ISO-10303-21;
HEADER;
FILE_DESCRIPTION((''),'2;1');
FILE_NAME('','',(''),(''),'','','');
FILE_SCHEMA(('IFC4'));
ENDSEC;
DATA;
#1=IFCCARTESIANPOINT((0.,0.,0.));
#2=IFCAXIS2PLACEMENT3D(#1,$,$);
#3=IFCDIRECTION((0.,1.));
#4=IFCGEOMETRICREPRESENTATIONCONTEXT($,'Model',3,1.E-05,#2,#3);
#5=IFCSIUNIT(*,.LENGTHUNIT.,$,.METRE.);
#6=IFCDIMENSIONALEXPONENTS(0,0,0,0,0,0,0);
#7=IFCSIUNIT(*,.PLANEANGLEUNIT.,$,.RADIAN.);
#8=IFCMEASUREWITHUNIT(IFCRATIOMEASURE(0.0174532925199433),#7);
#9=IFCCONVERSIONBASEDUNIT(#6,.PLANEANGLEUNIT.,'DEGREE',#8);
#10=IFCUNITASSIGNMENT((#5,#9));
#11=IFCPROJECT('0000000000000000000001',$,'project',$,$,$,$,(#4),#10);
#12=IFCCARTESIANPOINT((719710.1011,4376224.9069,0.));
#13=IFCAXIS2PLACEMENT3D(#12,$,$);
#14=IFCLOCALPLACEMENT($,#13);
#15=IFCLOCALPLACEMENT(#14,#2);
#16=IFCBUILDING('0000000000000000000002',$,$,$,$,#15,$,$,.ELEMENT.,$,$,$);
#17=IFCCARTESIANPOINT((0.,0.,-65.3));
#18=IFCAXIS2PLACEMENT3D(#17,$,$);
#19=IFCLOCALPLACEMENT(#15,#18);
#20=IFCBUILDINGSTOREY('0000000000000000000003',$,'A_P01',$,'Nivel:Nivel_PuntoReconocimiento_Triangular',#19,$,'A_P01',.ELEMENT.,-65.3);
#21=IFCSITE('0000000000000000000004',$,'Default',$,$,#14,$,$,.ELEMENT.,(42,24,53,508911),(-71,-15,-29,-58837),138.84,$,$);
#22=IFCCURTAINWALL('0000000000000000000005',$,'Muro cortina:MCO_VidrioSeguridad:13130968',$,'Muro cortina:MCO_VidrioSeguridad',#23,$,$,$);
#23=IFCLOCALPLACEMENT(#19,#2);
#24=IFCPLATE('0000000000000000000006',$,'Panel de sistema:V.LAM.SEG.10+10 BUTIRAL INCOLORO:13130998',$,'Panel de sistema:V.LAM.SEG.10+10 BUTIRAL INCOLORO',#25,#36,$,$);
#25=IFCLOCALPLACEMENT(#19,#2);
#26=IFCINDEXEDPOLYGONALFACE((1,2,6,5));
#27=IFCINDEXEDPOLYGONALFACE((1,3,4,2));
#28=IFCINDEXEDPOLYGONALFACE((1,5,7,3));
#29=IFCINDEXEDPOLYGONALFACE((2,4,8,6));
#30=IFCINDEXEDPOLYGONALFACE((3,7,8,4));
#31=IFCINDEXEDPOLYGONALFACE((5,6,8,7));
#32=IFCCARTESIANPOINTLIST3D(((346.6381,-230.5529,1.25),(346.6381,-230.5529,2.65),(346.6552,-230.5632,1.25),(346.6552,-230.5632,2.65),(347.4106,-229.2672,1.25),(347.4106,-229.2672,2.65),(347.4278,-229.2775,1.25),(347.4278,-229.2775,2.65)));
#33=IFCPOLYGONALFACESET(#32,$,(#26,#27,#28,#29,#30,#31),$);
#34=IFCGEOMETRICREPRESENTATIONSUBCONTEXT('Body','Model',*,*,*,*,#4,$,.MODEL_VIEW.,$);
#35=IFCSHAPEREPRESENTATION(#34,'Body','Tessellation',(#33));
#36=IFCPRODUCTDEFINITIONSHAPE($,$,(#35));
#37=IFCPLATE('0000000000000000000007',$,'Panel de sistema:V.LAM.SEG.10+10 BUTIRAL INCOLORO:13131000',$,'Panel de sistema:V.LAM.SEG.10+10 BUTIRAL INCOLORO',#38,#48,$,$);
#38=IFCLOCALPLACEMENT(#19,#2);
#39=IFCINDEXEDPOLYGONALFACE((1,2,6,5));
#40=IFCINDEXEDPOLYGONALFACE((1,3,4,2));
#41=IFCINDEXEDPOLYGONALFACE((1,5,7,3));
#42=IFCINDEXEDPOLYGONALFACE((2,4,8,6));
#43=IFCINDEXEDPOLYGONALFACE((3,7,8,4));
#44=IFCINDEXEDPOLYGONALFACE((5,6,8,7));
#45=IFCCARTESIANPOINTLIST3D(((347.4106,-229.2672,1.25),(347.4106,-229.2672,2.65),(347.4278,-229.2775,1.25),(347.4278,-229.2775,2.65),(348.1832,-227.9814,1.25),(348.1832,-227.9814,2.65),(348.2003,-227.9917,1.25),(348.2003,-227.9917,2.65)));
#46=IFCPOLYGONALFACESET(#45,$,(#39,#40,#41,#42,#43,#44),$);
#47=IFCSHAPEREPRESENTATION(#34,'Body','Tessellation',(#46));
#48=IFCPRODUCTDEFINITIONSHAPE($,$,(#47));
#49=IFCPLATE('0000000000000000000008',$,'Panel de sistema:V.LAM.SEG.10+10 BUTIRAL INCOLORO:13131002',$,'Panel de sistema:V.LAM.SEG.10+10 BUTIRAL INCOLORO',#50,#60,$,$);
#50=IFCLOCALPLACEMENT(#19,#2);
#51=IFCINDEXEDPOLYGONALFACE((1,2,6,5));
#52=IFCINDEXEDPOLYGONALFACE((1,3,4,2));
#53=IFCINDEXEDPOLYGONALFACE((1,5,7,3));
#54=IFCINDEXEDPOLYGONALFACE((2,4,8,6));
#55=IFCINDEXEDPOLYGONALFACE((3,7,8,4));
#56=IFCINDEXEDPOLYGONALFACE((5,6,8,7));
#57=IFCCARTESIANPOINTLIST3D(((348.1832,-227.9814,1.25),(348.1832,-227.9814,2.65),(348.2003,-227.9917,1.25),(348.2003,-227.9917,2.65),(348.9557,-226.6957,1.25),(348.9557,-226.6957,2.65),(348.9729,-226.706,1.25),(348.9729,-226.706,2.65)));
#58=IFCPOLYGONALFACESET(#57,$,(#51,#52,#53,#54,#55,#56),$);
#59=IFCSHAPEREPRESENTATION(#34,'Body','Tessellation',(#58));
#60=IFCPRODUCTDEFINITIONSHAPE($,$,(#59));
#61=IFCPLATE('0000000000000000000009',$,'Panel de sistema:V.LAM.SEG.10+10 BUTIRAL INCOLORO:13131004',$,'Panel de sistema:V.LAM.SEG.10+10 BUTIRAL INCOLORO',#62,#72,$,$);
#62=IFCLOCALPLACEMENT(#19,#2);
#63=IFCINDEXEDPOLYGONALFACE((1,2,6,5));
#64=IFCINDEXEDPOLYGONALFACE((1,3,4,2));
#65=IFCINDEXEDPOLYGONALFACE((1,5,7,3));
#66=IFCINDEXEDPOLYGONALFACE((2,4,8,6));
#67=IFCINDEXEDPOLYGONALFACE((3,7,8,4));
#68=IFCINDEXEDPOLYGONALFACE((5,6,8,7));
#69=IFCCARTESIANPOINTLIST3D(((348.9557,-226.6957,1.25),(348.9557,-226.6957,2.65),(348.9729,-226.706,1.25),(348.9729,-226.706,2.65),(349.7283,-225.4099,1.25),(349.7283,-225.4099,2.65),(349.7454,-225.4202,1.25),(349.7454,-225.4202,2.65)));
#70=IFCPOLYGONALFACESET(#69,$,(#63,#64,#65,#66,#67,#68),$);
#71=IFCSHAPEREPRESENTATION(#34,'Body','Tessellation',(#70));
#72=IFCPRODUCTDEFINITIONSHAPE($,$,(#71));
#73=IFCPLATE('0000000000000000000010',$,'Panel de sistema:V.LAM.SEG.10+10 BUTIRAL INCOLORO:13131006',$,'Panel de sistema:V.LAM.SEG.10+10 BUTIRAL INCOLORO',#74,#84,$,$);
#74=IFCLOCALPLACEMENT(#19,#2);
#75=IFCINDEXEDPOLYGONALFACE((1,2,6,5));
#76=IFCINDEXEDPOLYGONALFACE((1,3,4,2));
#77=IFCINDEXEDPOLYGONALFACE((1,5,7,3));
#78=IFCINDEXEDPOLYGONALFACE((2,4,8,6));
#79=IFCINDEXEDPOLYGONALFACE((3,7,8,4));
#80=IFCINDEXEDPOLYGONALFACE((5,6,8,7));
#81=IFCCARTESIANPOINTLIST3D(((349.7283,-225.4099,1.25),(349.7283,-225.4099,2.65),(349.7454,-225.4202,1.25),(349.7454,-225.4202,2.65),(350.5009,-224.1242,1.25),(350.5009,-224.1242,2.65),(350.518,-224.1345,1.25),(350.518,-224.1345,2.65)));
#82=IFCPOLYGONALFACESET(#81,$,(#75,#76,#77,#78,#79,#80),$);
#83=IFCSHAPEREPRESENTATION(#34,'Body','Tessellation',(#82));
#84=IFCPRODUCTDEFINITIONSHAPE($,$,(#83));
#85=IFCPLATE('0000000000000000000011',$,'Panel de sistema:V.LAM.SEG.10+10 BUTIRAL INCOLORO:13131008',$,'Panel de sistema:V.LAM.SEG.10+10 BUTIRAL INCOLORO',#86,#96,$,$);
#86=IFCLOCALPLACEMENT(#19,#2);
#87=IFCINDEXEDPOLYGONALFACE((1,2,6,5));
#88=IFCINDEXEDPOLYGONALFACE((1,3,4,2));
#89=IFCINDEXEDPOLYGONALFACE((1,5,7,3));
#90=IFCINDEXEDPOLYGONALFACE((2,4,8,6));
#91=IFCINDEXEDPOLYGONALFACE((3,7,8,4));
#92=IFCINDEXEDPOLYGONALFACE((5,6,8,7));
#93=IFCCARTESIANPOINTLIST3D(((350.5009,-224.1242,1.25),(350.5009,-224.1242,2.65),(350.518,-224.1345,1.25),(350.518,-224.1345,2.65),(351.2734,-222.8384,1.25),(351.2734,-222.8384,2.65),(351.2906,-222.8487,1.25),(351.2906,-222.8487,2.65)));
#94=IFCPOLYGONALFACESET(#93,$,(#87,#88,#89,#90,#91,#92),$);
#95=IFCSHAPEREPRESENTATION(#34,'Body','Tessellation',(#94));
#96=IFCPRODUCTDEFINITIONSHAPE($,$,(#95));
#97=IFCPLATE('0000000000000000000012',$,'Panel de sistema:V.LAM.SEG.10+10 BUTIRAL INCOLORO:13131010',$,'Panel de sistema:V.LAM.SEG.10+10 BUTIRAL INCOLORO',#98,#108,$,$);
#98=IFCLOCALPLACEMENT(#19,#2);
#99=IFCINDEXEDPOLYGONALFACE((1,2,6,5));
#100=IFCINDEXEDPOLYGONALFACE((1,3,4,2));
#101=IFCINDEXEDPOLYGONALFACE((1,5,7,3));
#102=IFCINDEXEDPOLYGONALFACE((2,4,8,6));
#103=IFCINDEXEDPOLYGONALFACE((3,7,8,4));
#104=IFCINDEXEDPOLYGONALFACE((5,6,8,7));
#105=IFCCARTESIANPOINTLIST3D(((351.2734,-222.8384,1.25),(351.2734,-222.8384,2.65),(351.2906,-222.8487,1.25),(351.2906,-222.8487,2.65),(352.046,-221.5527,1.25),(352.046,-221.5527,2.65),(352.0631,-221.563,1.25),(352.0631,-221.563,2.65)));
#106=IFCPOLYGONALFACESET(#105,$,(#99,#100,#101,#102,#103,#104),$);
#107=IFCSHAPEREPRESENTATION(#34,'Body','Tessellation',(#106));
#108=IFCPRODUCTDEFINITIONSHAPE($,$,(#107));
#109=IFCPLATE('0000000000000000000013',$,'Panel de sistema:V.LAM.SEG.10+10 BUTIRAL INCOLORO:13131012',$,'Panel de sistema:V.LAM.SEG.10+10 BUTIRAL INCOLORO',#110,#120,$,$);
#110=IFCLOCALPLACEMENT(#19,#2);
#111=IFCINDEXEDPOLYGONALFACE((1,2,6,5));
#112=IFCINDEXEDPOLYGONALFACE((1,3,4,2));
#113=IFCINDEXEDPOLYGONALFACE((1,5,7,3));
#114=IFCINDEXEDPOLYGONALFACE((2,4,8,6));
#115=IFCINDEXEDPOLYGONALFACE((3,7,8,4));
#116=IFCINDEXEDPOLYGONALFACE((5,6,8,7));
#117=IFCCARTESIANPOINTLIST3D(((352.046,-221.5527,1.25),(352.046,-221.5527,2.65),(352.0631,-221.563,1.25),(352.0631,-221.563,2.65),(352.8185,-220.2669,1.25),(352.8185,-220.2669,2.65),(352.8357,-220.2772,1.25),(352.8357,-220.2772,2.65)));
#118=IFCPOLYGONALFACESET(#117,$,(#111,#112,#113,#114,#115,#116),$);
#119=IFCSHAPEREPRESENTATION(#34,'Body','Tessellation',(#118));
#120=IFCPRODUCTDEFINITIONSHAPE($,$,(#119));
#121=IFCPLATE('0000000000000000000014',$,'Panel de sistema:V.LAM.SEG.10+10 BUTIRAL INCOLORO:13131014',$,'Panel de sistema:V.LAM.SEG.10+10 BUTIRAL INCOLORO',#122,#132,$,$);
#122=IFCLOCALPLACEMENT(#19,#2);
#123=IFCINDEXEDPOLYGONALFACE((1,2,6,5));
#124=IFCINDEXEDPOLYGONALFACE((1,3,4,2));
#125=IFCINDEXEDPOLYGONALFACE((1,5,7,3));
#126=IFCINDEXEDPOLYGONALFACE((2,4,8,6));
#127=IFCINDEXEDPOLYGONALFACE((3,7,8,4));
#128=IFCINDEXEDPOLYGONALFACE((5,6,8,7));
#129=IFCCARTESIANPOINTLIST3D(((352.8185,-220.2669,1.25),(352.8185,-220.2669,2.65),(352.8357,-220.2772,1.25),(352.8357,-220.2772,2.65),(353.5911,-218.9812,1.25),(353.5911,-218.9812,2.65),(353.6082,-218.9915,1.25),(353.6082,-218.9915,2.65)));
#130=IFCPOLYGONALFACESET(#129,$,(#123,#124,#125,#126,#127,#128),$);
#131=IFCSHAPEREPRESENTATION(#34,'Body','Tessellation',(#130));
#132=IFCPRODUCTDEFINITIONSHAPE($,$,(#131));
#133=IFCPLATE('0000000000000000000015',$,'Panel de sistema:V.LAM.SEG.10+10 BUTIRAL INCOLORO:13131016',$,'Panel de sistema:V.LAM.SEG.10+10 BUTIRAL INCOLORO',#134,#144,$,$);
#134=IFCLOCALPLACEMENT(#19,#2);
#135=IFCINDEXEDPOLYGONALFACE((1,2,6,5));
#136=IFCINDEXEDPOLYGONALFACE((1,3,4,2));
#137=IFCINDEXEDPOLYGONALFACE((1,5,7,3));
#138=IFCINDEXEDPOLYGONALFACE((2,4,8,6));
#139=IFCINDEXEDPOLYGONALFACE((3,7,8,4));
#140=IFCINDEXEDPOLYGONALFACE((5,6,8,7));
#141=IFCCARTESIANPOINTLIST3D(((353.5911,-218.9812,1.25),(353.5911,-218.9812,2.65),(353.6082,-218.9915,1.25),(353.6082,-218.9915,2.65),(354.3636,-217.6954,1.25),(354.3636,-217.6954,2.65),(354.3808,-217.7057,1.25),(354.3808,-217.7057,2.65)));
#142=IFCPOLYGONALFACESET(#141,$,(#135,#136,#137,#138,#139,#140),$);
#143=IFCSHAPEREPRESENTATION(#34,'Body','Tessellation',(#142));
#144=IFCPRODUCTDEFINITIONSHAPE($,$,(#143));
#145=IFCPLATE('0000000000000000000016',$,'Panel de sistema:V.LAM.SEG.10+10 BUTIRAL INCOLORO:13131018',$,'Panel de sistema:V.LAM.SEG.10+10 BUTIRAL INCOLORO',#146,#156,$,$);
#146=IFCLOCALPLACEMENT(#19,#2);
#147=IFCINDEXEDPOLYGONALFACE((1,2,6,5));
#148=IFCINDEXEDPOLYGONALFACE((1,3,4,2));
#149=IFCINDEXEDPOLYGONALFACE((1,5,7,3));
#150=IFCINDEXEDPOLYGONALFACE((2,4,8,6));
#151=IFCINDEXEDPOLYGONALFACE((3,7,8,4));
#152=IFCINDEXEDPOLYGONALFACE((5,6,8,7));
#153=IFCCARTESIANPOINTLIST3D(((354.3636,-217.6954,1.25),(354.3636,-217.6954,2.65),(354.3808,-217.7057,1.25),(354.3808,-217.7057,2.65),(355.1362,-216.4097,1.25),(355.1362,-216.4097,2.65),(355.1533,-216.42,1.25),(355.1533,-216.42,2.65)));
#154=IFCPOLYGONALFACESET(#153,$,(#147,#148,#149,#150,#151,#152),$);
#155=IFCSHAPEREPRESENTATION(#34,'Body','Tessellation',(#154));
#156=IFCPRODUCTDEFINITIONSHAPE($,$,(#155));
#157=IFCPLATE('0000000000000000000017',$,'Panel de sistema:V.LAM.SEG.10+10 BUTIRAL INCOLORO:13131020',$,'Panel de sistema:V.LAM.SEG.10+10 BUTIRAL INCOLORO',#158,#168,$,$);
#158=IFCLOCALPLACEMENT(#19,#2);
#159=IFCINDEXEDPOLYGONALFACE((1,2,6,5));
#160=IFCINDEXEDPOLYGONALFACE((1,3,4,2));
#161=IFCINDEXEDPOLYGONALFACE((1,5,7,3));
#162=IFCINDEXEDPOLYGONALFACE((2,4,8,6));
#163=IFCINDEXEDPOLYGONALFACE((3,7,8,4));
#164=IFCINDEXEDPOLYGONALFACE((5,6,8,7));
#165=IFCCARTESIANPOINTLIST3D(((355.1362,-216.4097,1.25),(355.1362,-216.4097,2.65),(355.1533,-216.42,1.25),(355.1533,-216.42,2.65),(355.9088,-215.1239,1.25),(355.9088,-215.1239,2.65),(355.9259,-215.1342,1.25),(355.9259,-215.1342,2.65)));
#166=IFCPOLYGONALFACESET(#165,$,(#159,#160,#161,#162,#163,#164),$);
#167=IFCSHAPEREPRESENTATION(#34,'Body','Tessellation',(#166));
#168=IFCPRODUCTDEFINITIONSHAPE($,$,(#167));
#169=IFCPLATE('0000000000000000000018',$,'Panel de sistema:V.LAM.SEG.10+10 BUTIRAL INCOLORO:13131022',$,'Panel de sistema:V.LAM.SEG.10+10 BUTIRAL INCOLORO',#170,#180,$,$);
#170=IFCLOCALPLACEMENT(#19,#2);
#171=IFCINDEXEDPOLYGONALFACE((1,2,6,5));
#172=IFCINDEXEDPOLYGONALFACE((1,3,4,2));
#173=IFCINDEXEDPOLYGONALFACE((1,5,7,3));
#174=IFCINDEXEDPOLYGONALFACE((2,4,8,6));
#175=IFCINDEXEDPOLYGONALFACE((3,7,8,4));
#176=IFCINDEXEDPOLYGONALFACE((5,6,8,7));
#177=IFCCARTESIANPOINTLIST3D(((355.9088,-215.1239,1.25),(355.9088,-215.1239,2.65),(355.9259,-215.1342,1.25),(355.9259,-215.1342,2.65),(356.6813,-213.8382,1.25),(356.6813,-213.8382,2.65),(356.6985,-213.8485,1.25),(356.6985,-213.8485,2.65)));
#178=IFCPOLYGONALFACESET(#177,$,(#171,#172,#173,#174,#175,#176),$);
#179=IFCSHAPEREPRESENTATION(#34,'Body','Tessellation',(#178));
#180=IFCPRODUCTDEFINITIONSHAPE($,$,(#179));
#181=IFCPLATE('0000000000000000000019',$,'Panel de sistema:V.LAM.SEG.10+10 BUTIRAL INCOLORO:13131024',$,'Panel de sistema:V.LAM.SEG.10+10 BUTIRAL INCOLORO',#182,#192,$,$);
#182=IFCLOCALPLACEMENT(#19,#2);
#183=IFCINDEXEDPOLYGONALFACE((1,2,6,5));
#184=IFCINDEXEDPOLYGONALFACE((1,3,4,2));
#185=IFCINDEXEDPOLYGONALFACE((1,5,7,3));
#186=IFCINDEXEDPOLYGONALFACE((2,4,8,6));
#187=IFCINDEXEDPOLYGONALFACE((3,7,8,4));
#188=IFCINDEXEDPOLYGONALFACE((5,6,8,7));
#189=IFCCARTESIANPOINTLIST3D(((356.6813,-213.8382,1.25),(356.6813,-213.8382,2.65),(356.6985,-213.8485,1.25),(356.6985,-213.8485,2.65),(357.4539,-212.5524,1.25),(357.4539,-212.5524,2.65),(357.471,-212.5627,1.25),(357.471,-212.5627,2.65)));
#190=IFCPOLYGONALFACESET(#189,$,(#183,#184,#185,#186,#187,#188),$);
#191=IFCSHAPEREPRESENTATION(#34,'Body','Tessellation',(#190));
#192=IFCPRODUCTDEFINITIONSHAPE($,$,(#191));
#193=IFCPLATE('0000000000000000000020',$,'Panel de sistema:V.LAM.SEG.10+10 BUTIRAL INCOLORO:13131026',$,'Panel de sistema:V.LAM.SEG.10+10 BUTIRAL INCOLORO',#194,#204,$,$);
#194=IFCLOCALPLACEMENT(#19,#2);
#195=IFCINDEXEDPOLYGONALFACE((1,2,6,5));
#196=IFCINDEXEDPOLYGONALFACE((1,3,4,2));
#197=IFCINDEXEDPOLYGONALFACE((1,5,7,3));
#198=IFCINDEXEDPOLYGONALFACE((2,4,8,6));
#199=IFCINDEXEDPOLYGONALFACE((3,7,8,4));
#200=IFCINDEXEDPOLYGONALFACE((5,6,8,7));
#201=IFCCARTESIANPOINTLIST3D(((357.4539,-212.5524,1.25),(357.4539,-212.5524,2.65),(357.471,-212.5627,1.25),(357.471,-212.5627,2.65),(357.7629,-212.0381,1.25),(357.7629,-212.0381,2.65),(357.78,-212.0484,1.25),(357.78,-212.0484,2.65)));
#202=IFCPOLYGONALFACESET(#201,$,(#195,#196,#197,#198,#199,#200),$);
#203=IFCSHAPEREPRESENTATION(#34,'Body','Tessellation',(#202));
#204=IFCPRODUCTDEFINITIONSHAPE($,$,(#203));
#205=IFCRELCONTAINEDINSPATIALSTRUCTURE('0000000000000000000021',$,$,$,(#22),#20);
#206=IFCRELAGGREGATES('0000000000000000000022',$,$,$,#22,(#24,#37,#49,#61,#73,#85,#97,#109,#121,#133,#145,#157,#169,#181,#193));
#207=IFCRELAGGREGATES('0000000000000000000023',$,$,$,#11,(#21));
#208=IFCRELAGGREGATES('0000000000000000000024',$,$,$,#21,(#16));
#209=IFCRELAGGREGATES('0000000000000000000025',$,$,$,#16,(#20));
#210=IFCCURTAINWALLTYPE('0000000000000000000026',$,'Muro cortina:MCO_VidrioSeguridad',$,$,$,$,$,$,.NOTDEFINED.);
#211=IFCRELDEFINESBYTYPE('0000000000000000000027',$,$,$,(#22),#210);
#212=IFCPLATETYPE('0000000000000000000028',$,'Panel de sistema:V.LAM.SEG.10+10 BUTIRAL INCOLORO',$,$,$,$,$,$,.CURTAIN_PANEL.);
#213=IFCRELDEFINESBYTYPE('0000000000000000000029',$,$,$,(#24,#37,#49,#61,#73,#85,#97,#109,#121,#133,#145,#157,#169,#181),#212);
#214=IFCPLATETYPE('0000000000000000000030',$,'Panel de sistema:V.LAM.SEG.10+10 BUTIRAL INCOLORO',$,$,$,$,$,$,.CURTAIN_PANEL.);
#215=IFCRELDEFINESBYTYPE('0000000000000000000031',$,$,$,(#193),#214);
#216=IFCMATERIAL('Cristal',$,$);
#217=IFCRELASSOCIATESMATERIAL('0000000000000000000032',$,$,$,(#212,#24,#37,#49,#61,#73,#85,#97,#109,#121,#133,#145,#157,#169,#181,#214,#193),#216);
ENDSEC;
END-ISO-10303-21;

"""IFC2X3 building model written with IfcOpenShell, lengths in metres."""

from ifc_helpers import new_model, entity, si_unit, converted_unit, direction, frame, origin, origin_2d_with_axis, place, context, subcontext, project, spatial, rectangle, extrude, source, transform, mapped, material, type_object, type_shapes, element, aggregate, save


model = new_model("IFC2X3")

# Units and contexts
model_context = context("Model", 3, precision=1e-05, world=origin(), true_north=direction((0.0, 1.0)))
body_context = subcontext(model_context, "Body", "Model", "MODEL_VIEW")
ifc_project = project(units=[si_unit("LENGTHUNIT", "METRE"), converted_unit("PLANEANGLEUNIT", "DEGREE", entity("IfcRatioMeasure", 0.0174532925199433), si_unit("PLANEANGLEUNIT", "RADIAN"), dimensions=[0, 0, 0, 0, 0, 0, 0])], contexts=[model_context])

# Site, building, storey
site_placement = place(None, frame((719710.1011, 4376224.9069, 0.0)))
site = spatial("IfcSite", under=ifc_project, at=site_placement, Name="Default", CompositionType="ELEMENT", RefLatitude=(42, 24, 53, 508911), RefLongitude=(-71, -15, -29, -58837), RefElevation=138.84)
building_placement = place(site_placement, origin())
building = spatial("IfcBuilding", under=site, at=building_placement, CompositionType="ELEMENT")
storey_placement = place(building_placement, frame((0.0, 0.0, -65.3)))
storey = spatial("IfcBuildingStorey", under=building, at=storey_placement, Name="A_P01", ObjectType="Nivel:Nivel_PuntoReconocimiento_Triangular", LongName="A_P01", CompositionType="ELEMENT", Elevation=-65.3)

# Curtain wall, plates
curtain_wall_type = type_object("IfcCurtainWallType", Name="Muro cortina:MCO_VidrioSeguridad", PredefinedType="NOTDEFINED")
curtain_wall_placement = place(storey_placement, frame((0.0, 0.0, 65.3)))
curtain_wall = element("IfcCurtainWall", 1, at=curtain_wall_placement, inside=storey, type_object=curtain_wall_type, Name="Muro cortina:MCO_VidrioSeguridad:13130968", ObjectType="Muro cortina:MCO_VidrioSeguridad")
ifc_material_1 = material(Name="Cristal")
plate_type_1 = type_object("IfcPlateType", Name="Panel de sistema:V.LAM.SEG.10+10 BUTIRAL INCOLORO", PredefinedType="CURTAIN_PANEL", material=ifc_material_1)
shared_shape_1 = source(origin(), body_context, "Body", "SweptSolid", [
    extrude(rectangle(XDim=0.02, YDim=1.5, at=origin_2d_with_axis()), frame((0.0, 0.0, 0.0), z_axis=(0.0, 0.0, 1.0), x_axis=(0.0, 1.0, 0.0)), (0.0, 0.0, 1.0), 1.4),
])
type_shapes(plate_type_1, [shared_shape_1])
plate_1_placement = place(curtain_wall_placement, frame((347.0329, -229.9152, -64.05), z_axis=(0.0, 0.0, 1.0), x_axis=(0.515038, 0.857167, 0.0)))
plate_1 = element("IfcPlate", 2, at=plate_1_placement, type_object=plate_type_1, material=ifc_material_1, Name="Panel de sistema:V.LAM.SEG.10+10 BUTIRAL INCOLORO:13130998", ObjectType="Panel de sistema:V.LAM.SEG.10+10 BUTIRAL INCOLORO", context=body_context, shape_type="MappedRepresentation", body=[
    mapped(shared_shape_1, transform((0.0, 0.0, 0.0), scale=1.0)),
])
plate_2_placement = place(curtain_wall_placement, frame((347.8055, -228.6294, -64.05), z_axis=(0.0, 0.0, 1.0), x_axis=(0.515038, 0.857167, 0.0)))
plate_2 = element("IfcPlate", 3, at=plate_2_placement, type_object=plate_type_1, material=ifc_material_1, Name="Panel de sistema:V.LAM.SEG.10+10 BUTIRAL INCOLORO:13131000", ObjectType="Panel de sistema:V.LAM.SEG.10+10 BUTIRAL INCOLORO", context=body_context, shape_type="MappedRepresentation", body=[
    mapped(shared_shape_1, transform((0.0, 0.0, 0.0), scale=1.0)),
])
plate_3_placement = place(curtain_wall_placement, frame((348.578, -227.3437, -64.05), z_axis=(0.0, 0.0, 1.0), x_axis=(0.515038, 0.857167, 0.0)))
plate_3 = element("IfcPlate", 4, at=plate_3_placement, type_object=plate_type_1, material=ifc_material_1, Name="Panel de sistema:V.LAM.SEG.10+10 BUTIRAL INCOLORO:13131002", ObjectType="Panel de sistema:V.LAM.SEG.10+10 BUTIRAL INCOLORO", context=body_context, shape_type="MappedRepresentation", body=[
    mapped(shared_shape_1, transform((0.0, 0.0, 0.0), scale=1.0)),
])
plate_4_placement = place(curtain_wall_placement, frame((349.3506, -226.0579, -64.05), z_axis=(0.0, 0.0, 1.0), x_axis=(0.515038, 0.857167, 0.0)))
plate_4 = element("IfcPlate", 5, at=plate_4_placement, type_object=plate_type_1, material=ifc_material_1, Name="Panel de sistema:V.LAM.SEG.10+10 BUTIRAL INCOLORO:13131004", ObjectType="Panel de sistema:V.LAM.SEG.10+10 BUTIRAL INCOLORO", context=body_context, shape_type="MappedRepresentation", body=[
    mapped(shared_shape_1, transform((0.0, 0.0, 0.0), scale=1.0)),
])
plate_5_placement = place(curtain_wall_placement, frame((350.1232, -224.7722, -64.05), z_axis=(0.0, 0.0, 1.0), x_axis=(0.515038, 0.857167, 0.0)))
plate_5 = element("IfcPlate", 6, at=plate_5_placement, type_object=plate_type_1, material=ifc_material_1, Name="Panel de sistema:V.LAM.SEG.10+10 BUTIRAL INCOLORO:13131006", ObjectType="Panel de sistema:V.LAM.SEG.10+10 BUTIRAL INCOLORO", context=body_context, shape_type="MappedRepresentation", body=[
    mapped(shared_shape_1, transform((0.0, 0.0, 0.0), scale=1.0)),
])
plate_6_placement = place(curtain_wall_placement, frame((350.8957, -223.4864, -64.05), z_axis=(0.0, 0.0, 1.0), x_axis=(0.515038, 0.857167, 0.0)))
plate_6 = element("IfcPlate", 7, at=plate_6_placement, type_object=plate_type_1, material=ifc_material_1, Name="Panel de sistema:V.LAM.SEG.10+10 BUTIRAL INCOLORO:13131008", ObjectType="Panel de sistema:V.LAM.SEG.10+10 BUTIRAL INCOLORO", context=body_context, shape_type="MappedRepresentation", body=[
    mapped(shared_shape_1, transform((0.0, 0.0, 0.0), scale=1.0)),
])
plate_7_placement = place(curtain_wall_placement, frame((351.6683, -222.2007, -64.05), z_axis=(0.0, 0.0, 1.0), x_axis=(0.515038, 0.857167, 0.0)))
plate_7 = element("IfcPlate", 8, at=plate_7_placement, type_object=plate_type_1, material=ifc_material_1, Name="Panel de sistema:V.LAM.SEG.10+10 BUTIRAL INCOLORO:13131010", ObjectType="Panel de sistema:V.LAM.SEG.10+10 BUTIRAL INCOLORO", context=body_context, shape_type="MappedRepresentation", body=[
    mapped(shared_shape_1, transform((0.0, 0.0, 0.0), scale=1.0)),
])
plate_8_placement = place(curtain_wall_placement, frame((352.4408, -220.9149, -64.05), z_axis=(0.0, 0.0, 1.0), x_axis=(0.515038, 0.857167, 0.0)))
plate_8 = element("IfcPlate", 9, at=plate_8_placement, type_object=plate_type_1, material=ifc_material_1, Name="Panel de sistema:V.LAM.SEG.10+10 BUTIRAL INCOLORO:13131012", ObjectType="Panel de sistema:V.LAM.SEG.10+10 BUTIRAL INCOLORO", context=body_context, shape_type="MappedRepresentation", body=[
    mapped(shared_shape_1, transform((0.0, 0.0, 0.0), scale=1.0)),
])
plate_9_placement = place(curtain_wall_placement, frame((353.2134, -219.6292, -64.05), z_axis=(0.0, 0.0, 1.0), x_axis=(0.515038, 0.857167, 0.0)))
plate_9 = element("IfcPlate", 10, at=plate_9_placement, type_object=plate_type_1, material=ifc_material_1, Name="Panel de sistema:V.LAM.SEG.10+10 BUTIRAL INCOLORO:13131014", ObjectType="Panel de sistema:V.LAM.SEG.10+10 BUTIRAL INCOLORO", context=body_context, shape_type="MappedRepresentation", body=[
    mapped(shared_shape_1, transform((0.0, 0.0, 0.0), scale=1.0)),
])
plate_10_placement = place(curtain_wall_placement, frame((353.9859, -218.3434, -64.05), z_axis=(0.0, 0.0, 1.0), x_axis=(0.515038, 0.857167, 0.0)))
plate_10 = element("IfcPlate", 11, at=plate_10_placement, type_object=plate_type_1, material=ifc_material_1, Name="Panel de sistema:V.LAM.SEG.10+10 BUTIRAL INCOLORO:13131016", ObjectType="Panel de sistema:V.LAM.SEG.10+10 BUTIRAL INCOLORO", context=body_context, shape_type="MappedRepresentation", body=[
    mapped(shared_shape_1, transform((0.0, 0.0, 0.0), scale=1.0)),
])
plate_11_placement = place(curtain_wall_placement, frame((354.7585, -217.0577, -64.05), z_axis=(0.0, 0.0, 1.0), x_axis=(0.515038, 0.857167, 0.0)))
plate_11 = element("IfcPlate", 12, at=plate_11_placement, type_object=plate_type_1, material=ifc_material_1, Name="Panel de sistema:V.LAM.SEG.10+10 BUTIRAL INCOLORO:13131018", ObjectType="Panel de sistema:V.LAM.SEG.10+10 BUTIRAL INCOLORO", context=body_context, shape_type="MappedRepresentation", body=[
    mapped(shared_shape_1, transform((0.0, 0.0, 0.0), scale=1.0)),
])
plate_12_placement = place(curtain_wall_placement, frame((355.5311, -215.7719, -64.05), z_axis=(0.0, 0.0, 1.0), x_axis=(0.515038, 0.857167, 0.0)))
plate_12 = element("IfcPlate", 13, at=plate_12_placement, type_object=plate_type_1, material=ifc_material_1, Name="Panel de sistema:V.LAM.SEG.10+10 BUTIRAL INCOLORO:13131020", ObjectType="Panel de sistema:V.LAM.SEG.10+10 BUTIRAL INCOLORO", context=body_context, shape_type="MappedRepresentation", body=[
    mapped(shared_shape_1, transform((0.0, 0.0, 0.0), scale=1.0)),
])
plate_13_placement = place(curtain_wall_placement, frame((356.3036, -214.4862, -64.05), z_axis=(0.0, 0.0, 1.0), x_axis=(0.515038, 0.857167, 0.0)))
plate_13 = element("IfcPlate", 14, at=plate_13_placement, type_object=plate_type_1, material=ifc_material_1, Name="Panel de sistema:V.LAM.SEG.10+10 BUTIRAL INCOLORO:13131022", ObjectType="Panel de sistema:V.LAM.SEG.10+10 BUTIRAL INCOLORO", context=body_context, shape_type="MappedRepresentation", body=[
    mapped(shared_shape_1, transform((0.0, 0.0, 0.0), scale=1.0)),
])
plate_14_placement = place(curtain_wall_placement, frame((357.0762, -213.2004, -64.05), z_axis=(0.0, 0.0, 1.0), x_axis=(0.515038, 0.857167, 0.0)))
plate_14 = element("IfcPlate", 15, at=plate_14_placement, type_object=plate_type_1, material=ifc_material_1, Name="Panel de sistema:V.LAM.SEG.10+10 BUTIRAL INCOLORO:13131024", ObjectType="Panel de sistema:V.LAM.SEG.10+10 BUTIRAL INCOLORO", context=body_context, shape_type="MappedRepresentation", body=[
    mapped(shared_shape_1, transform((0.0, 0.0, 0.0), scale=1.0)),
])
plate_type_2 = type_object("IfcPlateType", Name="Panel de sistema:V.LAM.SEG.10+10 BUTIRAL INCOLORO", PredefinedType="CURTAIN_PANEL", material=ifc_material_1)
shared_shape_2 = source(origin(), body_context, "Body", "SweptSolid", [
    extrude(rectangle(XDim=0.02, YDim=0.6, at=origin_2d_with_axis()), frame((0.0, 0.0, 0.0), z_axis=(0.0, 0.0, 1.0), x_axis=(0.0, 1.0, 0.0)), (0.0, 0.0, 1.0), 1.4),
])
type_shapes(plate_type_2, [shared_shape_2])
plate_15_placement = place(curtain_wall_placement, frame((357.617, -212.3004, -64.05), z_axis=(0.0, 0.0, 1.0), x_axis=(0.515038, 0.857167, 0.0)))
plate_15 = element("IfcPlate", 16, at=plate_15_placement, type_object=plate_type_2, material=ifc_material_1, Name="Panel de sistema:V.LAM.SEG.10+10 BUTIRAL INCOLORO:13131026", ObjectType="Panel de sistema:V.LAM.SEG.10+10 BUTIRAL INCOLORO", context=body_context, shape_type="MappedRepresentation", body=[
    mapped(shared_shape_2, transform((0.0, 0.0, 0.0), scale=1.0)),
])
aggregate(curtain_wall, [plate_1, plate_2, plate_3, plate_4, plate_5, plate_6, plate_7, plate_8, plate_9, plate_10, plate_11, plate_12, plate_13, plate_14, plate_15])

save(model, "model.ifc")
